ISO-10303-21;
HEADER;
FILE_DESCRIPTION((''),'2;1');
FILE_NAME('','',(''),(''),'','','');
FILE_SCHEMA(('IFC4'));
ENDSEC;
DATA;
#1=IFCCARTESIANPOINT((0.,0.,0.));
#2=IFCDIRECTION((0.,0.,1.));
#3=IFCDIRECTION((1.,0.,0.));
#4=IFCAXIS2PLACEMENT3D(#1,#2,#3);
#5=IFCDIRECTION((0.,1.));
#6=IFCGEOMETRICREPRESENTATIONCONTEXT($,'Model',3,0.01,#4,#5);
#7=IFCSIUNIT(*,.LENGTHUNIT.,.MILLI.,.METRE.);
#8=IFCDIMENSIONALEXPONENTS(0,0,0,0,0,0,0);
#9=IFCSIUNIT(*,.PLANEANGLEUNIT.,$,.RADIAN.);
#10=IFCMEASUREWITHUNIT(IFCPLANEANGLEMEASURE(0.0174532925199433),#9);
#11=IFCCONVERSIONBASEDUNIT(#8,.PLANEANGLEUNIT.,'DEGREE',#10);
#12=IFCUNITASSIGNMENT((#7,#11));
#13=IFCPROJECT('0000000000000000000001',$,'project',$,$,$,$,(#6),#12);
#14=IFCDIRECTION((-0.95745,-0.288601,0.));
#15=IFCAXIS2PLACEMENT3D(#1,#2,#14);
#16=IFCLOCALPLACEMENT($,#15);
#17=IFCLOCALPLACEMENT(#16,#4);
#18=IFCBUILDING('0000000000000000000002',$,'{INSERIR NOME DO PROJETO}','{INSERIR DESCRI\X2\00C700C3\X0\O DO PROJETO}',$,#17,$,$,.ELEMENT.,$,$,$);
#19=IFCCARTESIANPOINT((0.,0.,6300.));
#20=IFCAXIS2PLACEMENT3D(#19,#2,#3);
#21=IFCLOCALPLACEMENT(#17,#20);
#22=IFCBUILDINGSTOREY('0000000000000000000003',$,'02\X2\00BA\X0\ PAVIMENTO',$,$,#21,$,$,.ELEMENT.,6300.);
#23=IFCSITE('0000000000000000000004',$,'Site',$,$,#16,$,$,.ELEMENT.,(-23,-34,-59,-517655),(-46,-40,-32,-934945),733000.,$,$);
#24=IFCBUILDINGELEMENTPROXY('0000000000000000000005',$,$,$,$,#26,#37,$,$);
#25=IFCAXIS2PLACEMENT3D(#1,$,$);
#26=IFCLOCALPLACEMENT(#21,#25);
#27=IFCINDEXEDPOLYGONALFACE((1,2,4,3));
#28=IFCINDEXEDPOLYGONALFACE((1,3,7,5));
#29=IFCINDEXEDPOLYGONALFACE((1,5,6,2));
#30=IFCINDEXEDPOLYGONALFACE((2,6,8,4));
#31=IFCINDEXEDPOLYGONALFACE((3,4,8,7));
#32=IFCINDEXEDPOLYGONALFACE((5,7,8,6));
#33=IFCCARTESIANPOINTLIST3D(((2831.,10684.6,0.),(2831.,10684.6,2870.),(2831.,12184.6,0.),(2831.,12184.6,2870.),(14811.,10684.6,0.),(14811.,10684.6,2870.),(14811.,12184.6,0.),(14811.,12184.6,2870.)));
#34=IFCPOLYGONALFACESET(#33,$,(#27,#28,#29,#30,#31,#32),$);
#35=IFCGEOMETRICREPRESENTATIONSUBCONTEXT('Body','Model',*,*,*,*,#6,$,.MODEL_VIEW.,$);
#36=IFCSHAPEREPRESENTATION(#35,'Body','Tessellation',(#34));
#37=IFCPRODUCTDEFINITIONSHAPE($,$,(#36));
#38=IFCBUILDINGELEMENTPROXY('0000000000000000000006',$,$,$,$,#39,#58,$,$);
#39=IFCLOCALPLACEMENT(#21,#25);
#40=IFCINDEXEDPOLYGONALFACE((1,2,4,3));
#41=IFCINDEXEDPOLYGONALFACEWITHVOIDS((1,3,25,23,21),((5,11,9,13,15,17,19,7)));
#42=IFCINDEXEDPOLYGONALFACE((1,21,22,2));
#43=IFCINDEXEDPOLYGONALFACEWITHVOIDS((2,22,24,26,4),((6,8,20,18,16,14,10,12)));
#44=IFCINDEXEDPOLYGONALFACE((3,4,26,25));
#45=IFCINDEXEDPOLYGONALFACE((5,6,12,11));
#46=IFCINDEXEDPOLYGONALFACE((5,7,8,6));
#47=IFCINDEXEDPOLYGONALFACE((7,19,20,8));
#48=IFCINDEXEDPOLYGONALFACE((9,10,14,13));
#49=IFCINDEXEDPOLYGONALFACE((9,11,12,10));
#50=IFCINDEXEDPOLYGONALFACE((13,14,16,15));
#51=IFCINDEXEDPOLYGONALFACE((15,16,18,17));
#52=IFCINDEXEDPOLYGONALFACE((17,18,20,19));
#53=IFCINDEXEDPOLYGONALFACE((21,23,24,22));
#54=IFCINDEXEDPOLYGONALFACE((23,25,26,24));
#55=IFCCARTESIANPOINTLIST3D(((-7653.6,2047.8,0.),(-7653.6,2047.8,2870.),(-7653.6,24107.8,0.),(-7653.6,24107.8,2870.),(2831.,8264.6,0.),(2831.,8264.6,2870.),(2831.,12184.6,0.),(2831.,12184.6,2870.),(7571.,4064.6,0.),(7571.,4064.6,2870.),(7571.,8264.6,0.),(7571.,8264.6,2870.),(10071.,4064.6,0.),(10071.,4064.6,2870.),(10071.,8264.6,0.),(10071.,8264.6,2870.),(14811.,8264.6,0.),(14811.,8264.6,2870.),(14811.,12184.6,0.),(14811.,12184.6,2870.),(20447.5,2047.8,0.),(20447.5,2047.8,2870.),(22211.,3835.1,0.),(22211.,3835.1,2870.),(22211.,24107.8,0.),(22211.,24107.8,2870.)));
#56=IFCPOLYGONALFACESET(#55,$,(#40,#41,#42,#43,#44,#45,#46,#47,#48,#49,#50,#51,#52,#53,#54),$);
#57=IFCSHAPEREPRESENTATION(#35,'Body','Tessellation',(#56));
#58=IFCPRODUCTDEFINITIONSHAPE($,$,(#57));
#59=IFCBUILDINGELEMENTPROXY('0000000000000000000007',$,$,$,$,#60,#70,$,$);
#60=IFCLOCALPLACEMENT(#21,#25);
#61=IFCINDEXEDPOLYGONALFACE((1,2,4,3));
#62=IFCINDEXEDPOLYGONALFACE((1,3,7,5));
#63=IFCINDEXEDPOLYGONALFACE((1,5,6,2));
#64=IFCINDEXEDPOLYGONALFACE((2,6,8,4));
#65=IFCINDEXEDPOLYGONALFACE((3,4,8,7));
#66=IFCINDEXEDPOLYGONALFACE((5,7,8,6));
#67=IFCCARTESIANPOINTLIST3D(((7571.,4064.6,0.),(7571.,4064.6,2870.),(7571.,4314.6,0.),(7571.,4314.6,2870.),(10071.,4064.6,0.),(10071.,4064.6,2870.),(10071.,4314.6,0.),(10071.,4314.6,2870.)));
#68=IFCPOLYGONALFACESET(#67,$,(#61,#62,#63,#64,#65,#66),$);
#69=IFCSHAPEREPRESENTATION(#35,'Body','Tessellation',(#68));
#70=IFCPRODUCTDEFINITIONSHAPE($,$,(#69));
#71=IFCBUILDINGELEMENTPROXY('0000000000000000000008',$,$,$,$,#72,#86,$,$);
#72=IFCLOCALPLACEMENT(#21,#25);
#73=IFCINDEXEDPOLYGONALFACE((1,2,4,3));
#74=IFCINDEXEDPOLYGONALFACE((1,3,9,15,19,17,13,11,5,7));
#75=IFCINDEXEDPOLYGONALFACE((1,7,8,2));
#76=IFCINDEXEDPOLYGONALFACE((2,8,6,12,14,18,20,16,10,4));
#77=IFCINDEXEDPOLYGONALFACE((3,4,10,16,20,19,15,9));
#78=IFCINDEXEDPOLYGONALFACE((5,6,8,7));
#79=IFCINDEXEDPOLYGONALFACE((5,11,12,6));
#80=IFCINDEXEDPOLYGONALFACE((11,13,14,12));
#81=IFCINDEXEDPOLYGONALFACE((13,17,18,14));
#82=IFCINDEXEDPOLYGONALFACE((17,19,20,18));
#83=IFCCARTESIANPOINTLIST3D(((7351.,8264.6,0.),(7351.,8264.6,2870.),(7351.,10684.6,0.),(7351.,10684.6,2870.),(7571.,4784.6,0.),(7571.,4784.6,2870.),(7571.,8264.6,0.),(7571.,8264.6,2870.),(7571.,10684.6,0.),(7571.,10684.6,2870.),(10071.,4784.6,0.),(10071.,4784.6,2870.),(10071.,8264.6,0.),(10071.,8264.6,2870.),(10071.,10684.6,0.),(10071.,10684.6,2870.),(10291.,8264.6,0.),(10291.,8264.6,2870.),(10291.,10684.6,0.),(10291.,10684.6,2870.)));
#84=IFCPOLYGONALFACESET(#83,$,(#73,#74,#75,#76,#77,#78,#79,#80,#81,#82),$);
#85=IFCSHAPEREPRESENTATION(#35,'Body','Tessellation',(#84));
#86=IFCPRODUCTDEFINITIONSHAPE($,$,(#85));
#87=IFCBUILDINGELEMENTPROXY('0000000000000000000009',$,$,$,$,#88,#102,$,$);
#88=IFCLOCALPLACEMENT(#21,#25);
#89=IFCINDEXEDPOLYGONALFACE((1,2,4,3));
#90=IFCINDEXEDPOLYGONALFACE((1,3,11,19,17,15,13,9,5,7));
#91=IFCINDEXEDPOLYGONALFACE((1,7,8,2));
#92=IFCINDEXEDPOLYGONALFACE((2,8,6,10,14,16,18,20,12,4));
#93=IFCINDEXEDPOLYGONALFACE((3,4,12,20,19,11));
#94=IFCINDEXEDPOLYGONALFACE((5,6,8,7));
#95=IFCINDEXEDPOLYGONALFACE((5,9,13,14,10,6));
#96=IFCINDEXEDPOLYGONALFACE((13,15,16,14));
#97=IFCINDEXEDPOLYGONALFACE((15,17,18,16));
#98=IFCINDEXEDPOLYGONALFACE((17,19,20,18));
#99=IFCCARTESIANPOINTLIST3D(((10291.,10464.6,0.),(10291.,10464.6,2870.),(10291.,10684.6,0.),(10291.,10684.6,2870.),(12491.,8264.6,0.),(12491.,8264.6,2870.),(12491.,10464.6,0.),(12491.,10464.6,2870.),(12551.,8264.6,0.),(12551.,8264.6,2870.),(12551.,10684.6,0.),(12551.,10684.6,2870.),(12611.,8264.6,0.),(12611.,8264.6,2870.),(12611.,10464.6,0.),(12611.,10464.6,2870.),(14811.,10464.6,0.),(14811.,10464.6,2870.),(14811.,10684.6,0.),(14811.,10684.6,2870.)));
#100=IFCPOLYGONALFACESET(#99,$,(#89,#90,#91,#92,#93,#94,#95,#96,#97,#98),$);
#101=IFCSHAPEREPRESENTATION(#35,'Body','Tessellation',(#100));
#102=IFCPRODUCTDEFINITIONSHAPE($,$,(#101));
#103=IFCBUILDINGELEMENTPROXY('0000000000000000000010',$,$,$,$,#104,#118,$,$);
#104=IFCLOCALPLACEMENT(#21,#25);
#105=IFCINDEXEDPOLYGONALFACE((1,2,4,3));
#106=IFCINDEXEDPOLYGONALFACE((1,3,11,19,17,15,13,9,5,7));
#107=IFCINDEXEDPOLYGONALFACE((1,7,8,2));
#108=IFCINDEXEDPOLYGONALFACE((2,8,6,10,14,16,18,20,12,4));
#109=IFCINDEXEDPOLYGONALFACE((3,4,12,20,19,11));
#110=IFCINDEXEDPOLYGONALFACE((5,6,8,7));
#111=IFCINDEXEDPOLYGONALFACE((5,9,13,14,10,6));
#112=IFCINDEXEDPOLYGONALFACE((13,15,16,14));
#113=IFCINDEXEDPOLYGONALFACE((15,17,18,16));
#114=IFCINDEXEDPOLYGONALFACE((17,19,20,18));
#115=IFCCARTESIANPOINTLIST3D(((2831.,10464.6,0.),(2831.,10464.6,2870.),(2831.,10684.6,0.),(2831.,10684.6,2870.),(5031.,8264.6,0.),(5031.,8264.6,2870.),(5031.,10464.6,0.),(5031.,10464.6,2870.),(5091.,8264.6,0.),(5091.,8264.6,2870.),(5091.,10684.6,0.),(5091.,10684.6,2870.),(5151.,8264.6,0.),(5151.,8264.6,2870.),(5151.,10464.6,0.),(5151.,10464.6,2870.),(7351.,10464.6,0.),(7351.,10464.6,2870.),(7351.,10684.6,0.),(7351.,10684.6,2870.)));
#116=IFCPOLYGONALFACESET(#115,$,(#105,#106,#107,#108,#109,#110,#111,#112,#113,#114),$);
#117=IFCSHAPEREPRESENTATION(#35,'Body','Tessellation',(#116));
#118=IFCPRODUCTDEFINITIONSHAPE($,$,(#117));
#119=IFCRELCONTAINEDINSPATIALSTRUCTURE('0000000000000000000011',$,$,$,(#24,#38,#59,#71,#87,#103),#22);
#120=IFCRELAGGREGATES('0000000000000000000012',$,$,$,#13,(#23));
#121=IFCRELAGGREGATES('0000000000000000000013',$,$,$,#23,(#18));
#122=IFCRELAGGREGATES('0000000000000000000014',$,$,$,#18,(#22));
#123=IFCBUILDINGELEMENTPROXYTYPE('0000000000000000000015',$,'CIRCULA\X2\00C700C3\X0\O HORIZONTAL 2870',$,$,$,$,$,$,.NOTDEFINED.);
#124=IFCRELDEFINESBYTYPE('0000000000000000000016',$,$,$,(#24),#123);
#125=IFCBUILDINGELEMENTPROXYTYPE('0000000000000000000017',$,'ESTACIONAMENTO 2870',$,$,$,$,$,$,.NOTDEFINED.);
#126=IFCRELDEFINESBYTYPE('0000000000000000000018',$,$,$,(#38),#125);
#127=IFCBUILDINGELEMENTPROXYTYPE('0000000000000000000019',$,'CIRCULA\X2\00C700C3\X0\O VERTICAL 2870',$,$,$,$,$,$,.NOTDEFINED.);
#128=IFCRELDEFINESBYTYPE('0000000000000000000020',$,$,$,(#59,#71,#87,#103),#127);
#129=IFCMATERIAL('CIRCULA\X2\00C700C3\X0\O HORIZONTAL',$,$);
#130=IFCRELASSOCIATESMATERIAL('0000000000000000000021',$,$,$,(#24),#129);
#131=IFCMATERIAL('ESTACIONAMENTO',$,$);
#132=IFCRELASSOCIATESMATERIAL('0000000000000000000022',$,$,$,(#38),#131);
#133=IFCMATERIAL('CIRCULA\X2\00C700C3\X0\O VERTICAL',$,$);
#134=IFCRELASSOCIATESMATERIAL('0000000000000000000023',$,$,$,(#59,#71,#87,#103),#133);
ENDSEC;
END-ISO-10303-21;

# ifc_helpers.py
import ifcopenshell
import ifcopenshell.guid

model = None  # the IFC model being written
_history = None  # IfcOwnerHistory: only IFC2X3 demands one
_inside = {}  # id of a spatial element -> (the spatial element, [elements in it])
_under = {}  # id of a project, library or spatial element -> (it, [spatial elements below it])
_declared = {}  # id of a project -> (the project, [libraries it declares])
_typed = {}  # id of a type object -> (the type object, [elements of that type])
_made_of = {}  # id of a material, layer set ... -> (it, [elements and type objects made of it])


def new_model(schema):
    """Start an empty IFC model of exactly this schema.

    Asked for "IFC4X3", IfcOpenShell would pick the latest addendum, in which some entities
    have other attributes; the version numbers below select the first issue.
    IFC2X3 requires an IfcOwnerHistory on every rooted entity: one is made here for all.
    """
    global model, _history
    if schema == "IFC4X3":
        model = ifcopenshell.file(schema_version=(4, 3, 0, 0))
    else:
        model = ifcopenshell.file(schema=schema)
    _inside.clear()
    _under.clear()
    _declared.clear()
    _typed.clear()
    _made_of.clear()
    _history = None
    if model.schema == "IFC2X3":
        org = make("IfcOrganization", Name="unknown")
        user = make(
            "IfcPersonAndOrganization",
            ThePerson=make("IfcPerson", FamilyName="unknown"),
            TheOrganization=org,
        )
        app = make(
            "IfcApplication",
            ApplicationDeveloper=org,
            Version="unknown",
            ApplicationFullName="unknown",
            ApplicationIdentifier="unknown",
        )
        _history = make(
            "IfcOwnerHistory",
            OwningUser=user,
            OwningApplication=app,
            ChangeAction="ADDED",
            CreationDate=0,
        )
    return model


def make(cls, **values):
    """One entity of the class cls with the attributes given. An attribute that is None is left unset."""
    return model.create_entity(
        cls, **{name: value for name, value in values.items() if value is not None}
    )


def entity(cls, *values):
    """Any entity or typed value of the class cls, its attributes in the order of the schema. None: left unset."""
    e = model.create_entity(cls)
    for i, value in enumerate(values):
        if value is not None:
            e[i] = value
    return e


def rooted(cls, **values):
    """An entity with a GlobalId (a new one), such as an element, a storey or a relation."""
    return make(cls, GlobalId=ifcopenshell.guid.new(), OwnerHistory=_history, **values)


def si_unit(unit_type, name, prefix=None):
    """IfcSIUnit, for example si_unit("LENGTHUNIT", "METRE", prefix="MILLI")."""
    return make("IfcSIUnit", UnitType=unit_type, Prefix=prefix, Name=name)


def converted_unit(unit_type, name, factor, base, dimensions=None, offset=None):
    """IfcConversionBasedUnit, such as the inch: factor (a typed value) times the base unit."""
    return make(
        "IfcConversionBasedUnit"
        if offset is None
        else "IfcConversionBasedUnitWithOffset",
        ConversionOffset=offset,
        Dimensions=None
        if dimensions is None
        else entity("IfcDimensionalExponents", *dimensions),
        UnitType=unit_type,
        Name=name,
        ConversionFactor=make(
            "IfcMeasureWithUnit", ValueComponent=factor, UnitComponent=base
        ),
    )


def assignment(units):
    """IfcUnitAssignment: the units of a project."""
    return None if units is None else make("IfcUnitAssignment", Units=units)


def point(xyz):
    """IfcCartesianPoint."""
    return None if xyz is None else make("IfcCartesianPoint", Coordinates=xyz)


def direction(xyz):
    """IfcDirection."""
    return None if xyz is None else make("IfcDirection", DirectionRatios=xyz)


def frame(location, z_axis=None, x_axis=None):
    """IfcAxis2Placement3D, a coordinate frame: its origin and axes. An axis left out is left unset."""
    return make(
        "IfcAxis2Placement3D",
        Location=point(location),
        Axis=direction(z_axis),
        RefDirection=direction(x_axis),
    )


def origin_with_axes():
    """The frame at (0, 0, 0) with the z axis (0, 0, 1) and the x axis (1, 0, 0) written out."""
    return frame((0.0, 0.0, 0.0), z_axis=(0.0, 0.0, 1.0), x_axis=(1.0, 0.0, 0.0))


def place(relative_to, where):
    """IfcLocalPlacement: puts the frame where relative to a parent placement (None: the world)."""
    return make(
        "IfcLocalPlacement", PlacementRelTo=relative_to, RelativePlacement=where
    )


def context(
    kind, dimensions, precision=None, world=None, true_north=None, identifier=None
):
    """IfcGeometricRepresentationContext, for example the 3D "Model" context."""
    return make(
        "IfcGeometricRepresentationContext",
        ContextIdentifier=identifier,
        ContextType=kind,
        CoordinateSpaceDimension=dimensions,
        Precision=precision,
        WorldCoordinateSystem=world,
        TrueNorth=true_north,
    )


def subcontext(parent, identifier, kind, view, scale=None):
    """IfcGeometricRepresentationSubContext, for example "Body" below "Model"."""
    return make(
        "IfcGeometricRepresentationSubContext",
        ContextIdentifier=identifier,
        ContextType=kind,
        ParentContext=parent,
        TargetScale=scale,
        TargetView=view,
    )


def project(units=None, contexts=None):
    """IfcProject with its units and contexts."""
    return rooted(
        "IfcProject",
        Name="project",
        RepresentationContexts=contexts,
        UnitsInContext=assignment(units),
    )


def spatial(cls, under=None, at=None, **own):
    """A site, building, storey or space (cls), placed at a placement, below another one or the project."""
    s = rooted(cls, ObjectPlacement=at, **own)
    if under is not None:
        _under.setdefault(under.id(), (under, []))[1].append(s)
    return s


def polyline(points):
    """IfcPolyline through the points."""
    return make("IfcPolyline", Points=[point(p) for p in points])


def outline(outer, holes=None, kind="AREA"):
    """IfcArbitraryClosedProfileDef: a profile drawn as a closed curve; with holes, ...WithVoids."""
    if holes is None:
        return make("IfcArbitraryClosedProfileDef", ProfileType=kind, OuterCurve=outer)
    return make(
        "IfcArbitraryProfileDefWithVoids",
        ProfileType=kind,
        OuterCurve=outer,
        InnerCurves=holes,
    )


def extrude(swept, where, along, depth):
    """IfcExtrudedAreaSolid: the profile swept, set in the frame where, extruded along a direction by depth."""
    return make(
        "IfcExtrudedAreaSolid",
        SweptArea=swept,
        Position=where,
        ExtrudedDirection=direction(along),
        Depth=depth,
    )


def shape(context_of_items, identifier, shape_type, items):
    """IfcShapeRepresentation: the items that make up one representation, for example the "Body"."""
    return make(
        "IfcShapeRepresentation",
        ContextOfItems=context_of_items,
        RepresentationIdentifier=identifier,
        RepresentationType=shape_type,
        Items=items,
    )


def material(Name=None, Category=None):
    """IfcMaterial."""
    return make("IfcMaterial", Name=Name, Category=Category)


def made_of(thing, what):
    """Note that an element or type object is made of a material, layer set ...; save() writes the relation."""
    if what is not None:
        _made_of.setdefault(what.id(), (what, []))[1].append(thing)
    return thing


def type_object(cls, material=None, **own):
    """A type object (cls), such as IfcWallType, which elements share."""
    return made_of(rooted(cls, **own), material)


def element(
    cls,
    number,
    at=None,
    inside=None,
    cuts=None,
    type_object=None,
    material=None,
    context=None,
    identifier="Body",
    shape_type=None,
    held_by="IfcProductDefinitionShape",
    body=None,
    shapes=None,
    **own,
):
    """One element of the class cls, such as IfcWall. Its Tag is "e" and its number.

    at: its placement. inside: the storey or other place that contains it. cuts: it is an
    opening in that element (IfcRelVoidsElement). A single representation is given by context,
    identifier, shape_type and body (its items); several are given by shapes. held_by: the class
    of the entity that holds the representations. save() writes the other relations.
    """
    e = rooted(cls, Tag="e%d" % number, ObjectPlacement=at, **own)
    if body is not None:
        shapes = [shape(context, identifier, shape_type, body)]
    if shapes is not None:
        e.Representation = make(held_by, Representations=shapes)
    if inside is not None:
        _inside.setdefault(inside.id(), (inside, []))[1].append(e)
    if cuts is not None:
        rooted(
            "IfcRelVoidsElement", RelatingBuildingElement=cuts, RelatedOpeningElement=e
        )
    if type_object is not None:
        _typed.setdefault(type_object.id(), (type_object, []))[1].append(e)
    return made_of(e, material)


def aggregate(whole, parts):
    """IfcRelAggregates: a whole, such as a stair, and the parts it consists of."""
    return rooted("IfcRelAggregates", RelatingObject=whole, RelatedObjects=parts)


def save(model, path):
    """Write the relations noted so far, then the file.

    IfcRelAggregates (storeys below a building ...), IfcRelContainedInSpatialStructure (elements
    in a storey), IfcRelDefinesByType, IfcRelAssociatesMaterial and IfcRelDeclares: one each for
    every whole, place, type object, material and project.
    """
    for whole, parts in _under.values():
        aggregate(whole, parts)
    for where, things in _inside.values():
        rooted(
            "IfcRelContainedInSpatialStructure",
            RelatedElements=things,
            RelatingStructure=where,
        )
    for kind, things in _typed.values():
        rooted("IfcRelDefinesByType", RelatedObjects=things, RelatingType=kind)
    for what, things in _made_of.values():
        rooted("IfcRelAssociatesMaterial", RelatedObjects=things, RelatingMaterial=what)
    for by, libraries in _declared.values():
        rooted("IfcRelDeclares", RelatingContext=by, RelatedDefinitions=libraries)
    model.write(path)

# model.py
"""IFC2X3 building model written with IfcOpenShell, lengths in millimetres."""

from ifc_helpers import new_model, entity, si_unit, converted_unit, direction, frame, origin_with_axes, place, context, subcontext, project, spatial, polyline, outline, extrude, material, type_object, element, save


model = new_model("IFC2X3")

# Units and contexts
model_context = context("Model", 3, precision=0.01, world=origin_with_axes(), true_north=direction((0.0, 1.0)))
body_context = subcontext(model_context, "Body", "Model", "MODEL_VIEW")
ifc_project = project(units=[si_unit("LENGTHUNIT", "METRE", prefix="MILLI"), converted_unit("PLANEANGLEUNIT", "DEGREE", entity("IfcPlaneAngleMeasure", 0.0174532925199433), si_unit("PLANEANGLEUNIT", "RADIAN"), dimensions=[0, 0, 0, 0, 0, 0, 0])], contexts=[model_context])

# Site, building, storey
site_placement = place(None, frame((0.0, 0.0, 0.0), z_axis=(0.0, 0.0, 1.0), x_axis=(-0.95745, -0.288601, 0.0)))
site = spatial("IfcSite", under=ifc_project, at=site_placement, Name="Site", CompositionType="ELEMENT", RefLatitude=(-23, -34, -59, -517655), RefLongitude=(-46, -40, -32, -934945), RefElevation=733000.0)
building_placement = place(site_placement, origin_with_axes())
building = spatial("IfcBuilding", under=site, at=building_placement, Name="{INSERIR NOME DO PROJETO}", Description="{INSERIR DESCRIÇÃO DO PROJETO}", CompositionType="ELEMENT")
storey_placement = place(building_placement, frame((0.0, 0.0, 6300.0), z_axis=(0.0, 0.0, 1.0), x_axis=(1.0, 0.0, 0.0)))
storey = spatial("IfcBuildingStorey", under=building, at=storey_placement, Name="02º PAVIMENTO", CompositionType="ELEMENT", Elevation=6300.0)

# Building element proxies
ifc_material_1 = material(Name="CIRCULAÇÃO HORIZONTAL")
building_element_proxy_type_1 = type_object("IfcBuildingElementProxyType", Name="CIRCULAÇÃO HORIZONTAL 2870", PredefinedType="NOTDEFINED")
proxy_1_placement = place(storey_placement, frame((2831.0, 10684.6, 0.0), z_axis=(0.0, 0.0, 1.0), x_axis=(1.0, 0.0, 0.0)))
element("IfcBuildingElementProxy", 1, at=proxy_1_placement, inside=storey, type_object=building_element_proxy_type_1, material=ifc_material_1, context=body_context, shape_type="SweptSolid", body=[
    extrude(outline(polyline([(0.0, 0.0), (11980.0, 0.0), (11980.0, 1500.0), (0.0, 1500.0), (0.0, 0.0)])), origin_with_axes(), (0.0, 0.0, 1.0), 2870.0),
])
ifc_material_2 = material(Name="ESTACIONAMENTO")
building_element_proxy_type_2 = type_object("IfcBuildingElementProxyType", Name="ESTACIONAMENTO 2870", PredefinedType="NOTDEFINED")
proxy_2_placement = place(storey_placement, frame((-7653.6, 2047.8, 0.0), z_axis=(0.0, 0.0, 1.0), x_axis=(1.0, 0.0, 0.0)))
element("IfcBuildingElementProxy", 2, at=proxy_2_placement, inside=storey, type_object=building_element_proxy_type_2, material=ifc_material_2, context=body_context, shape_type="SweptSolid", body=[
    extrude(outline(polyline([(0.0, 0.0), (28101.1, 0.0), (29864.6, 1787.4), (29864.6, 22060.0), (0.0, 22060.0), (0.0, 0.0)]), holes=[polyline([(10484.6, 6216.8), (10484.6, 10136.8), (22464.6, 10136.8), (22464.6, 6216.8), (17724.6, 6216.8), (17724.6, 2016.8), (15224.6, 2016.8), (15224.6, 6216.8), (10484.6, 6216.8)])]), origin_with_axes(), (0.0, 0.0, 1.0), 2870.0),
])
ifc_material_3 = material(Name="CIRCULAÇÃO VERTICAL")
building_element_proxy_type_3 = type_object("IfcBuildingElementProxyType", Name="CIRCULAÇÃO VERTICAL 2870", PredefinedType="NOTDEFINED")
proxy_3_placement = place(storey_placement, frame((7571.0, 4064.6, 0.0), z_axis=(0.0, 0.0, 1.0), x_axis=(1.0, 0.0, 0.0)))
element("IfcBuildingElementProxy", 3, at=proxy_3_placement, inside=storey, type_object=building_element_proxy_type_3, material=ifc_material_3, context=body_context, shape_type="SweptSolid", body=[
    extrude(outline(polyline([(0.0, 0.0), (2500.0, 0.0), (2500.0, 250.0), (0.0, 250.0), (0.0, 0.0)])), origin_with_axes(), (0.0, 0.0, 1.0), 2870.0),
])
proxy_4_placement = place(storey_placement, frame((7351.0, 10684.6, 0.0), z_axis=(0.0, 0.0, 1.0), x_axis=(1.0, 0.0, 0.0)))
element("IfcBuildingElementProxy", 4, at=proxy_4_placement, inside=storey, type_object=building_element_proxy_type_3, material=ifc_material_3, context=body_context, shape_type="SweptSolid", body=[
    extrude(outline(polyline([(0.0, 0.0), (0.0, -2420.0), (220.0, -2420.0), (220.0, -5900.0), (2720.0, -5900.0), (2720.0, -2420.0), (2940.0, -2420.0), (2940.0, 0.0), (2720.0, 0.0), (220.0, 0.0), (0.0, 0.0)])), origin_with_axes(), (0.0, 0.0, 1.0), 2870.0),
])
proxy_5_placement = place(storey_placement, frame((10291.0, 10684.6, 0.0), z_axis=(0.0, 0.0, 1.0), x_axis=(1.0, 0.0, 0.0)))
element("IfcBuildingElementProxy", 5, at=proxy_5_placement, inside=storey, type_object=building_element_proxy_type_3, material=ifc_material_3, context=body_context, shape_type="SweptSolid", body=[
    extrude(outline(polyline([(0.0, 0.0), (0.0, -220.0), (2200.0, -220.0), (2200.0, -2420.0), (2260.0, -2420.0), (2320.0, -2420.0), (2320.0, -220.0), (4520.0, -220.0), (4520.0, 0.0), (2260.0, 0.0), (0.0, 0.0)])), origin_with_axes(), (0.0, 0.0, 1.0), 2870.0),
])
proxy_6_placement = place(storey_placement, frame((5091.0, 10684.6, 0.0), z_axis=(0.0, 0.0, 1.0), x_axis=(1.0, 0.0, 0.0)))
element("IfcBuildingElementProxy", 6, at=proxy_6_placement, inside=storey, type_object=building_element_proxy_type_3, material=ifc_material_3, context=body_context, shape_type="SweptSolid", body=[
    extrude(outline(polyline([(0.0, 0.0), (-2260.0, 0.0), (-2260.0, -220.0), (-60.0, -220.0), (-60.0, -2420.0), (0.0, -2420.0), (60.0, -2420.0), (60.0, -220.0), (2260.0, -220.0), (2260.0, 0.0), (0.0, 0.0)])), origin_with_axes(), (0.0, 0.0, 1.0), 2870.0),
])

save(model, "model.ifc")
